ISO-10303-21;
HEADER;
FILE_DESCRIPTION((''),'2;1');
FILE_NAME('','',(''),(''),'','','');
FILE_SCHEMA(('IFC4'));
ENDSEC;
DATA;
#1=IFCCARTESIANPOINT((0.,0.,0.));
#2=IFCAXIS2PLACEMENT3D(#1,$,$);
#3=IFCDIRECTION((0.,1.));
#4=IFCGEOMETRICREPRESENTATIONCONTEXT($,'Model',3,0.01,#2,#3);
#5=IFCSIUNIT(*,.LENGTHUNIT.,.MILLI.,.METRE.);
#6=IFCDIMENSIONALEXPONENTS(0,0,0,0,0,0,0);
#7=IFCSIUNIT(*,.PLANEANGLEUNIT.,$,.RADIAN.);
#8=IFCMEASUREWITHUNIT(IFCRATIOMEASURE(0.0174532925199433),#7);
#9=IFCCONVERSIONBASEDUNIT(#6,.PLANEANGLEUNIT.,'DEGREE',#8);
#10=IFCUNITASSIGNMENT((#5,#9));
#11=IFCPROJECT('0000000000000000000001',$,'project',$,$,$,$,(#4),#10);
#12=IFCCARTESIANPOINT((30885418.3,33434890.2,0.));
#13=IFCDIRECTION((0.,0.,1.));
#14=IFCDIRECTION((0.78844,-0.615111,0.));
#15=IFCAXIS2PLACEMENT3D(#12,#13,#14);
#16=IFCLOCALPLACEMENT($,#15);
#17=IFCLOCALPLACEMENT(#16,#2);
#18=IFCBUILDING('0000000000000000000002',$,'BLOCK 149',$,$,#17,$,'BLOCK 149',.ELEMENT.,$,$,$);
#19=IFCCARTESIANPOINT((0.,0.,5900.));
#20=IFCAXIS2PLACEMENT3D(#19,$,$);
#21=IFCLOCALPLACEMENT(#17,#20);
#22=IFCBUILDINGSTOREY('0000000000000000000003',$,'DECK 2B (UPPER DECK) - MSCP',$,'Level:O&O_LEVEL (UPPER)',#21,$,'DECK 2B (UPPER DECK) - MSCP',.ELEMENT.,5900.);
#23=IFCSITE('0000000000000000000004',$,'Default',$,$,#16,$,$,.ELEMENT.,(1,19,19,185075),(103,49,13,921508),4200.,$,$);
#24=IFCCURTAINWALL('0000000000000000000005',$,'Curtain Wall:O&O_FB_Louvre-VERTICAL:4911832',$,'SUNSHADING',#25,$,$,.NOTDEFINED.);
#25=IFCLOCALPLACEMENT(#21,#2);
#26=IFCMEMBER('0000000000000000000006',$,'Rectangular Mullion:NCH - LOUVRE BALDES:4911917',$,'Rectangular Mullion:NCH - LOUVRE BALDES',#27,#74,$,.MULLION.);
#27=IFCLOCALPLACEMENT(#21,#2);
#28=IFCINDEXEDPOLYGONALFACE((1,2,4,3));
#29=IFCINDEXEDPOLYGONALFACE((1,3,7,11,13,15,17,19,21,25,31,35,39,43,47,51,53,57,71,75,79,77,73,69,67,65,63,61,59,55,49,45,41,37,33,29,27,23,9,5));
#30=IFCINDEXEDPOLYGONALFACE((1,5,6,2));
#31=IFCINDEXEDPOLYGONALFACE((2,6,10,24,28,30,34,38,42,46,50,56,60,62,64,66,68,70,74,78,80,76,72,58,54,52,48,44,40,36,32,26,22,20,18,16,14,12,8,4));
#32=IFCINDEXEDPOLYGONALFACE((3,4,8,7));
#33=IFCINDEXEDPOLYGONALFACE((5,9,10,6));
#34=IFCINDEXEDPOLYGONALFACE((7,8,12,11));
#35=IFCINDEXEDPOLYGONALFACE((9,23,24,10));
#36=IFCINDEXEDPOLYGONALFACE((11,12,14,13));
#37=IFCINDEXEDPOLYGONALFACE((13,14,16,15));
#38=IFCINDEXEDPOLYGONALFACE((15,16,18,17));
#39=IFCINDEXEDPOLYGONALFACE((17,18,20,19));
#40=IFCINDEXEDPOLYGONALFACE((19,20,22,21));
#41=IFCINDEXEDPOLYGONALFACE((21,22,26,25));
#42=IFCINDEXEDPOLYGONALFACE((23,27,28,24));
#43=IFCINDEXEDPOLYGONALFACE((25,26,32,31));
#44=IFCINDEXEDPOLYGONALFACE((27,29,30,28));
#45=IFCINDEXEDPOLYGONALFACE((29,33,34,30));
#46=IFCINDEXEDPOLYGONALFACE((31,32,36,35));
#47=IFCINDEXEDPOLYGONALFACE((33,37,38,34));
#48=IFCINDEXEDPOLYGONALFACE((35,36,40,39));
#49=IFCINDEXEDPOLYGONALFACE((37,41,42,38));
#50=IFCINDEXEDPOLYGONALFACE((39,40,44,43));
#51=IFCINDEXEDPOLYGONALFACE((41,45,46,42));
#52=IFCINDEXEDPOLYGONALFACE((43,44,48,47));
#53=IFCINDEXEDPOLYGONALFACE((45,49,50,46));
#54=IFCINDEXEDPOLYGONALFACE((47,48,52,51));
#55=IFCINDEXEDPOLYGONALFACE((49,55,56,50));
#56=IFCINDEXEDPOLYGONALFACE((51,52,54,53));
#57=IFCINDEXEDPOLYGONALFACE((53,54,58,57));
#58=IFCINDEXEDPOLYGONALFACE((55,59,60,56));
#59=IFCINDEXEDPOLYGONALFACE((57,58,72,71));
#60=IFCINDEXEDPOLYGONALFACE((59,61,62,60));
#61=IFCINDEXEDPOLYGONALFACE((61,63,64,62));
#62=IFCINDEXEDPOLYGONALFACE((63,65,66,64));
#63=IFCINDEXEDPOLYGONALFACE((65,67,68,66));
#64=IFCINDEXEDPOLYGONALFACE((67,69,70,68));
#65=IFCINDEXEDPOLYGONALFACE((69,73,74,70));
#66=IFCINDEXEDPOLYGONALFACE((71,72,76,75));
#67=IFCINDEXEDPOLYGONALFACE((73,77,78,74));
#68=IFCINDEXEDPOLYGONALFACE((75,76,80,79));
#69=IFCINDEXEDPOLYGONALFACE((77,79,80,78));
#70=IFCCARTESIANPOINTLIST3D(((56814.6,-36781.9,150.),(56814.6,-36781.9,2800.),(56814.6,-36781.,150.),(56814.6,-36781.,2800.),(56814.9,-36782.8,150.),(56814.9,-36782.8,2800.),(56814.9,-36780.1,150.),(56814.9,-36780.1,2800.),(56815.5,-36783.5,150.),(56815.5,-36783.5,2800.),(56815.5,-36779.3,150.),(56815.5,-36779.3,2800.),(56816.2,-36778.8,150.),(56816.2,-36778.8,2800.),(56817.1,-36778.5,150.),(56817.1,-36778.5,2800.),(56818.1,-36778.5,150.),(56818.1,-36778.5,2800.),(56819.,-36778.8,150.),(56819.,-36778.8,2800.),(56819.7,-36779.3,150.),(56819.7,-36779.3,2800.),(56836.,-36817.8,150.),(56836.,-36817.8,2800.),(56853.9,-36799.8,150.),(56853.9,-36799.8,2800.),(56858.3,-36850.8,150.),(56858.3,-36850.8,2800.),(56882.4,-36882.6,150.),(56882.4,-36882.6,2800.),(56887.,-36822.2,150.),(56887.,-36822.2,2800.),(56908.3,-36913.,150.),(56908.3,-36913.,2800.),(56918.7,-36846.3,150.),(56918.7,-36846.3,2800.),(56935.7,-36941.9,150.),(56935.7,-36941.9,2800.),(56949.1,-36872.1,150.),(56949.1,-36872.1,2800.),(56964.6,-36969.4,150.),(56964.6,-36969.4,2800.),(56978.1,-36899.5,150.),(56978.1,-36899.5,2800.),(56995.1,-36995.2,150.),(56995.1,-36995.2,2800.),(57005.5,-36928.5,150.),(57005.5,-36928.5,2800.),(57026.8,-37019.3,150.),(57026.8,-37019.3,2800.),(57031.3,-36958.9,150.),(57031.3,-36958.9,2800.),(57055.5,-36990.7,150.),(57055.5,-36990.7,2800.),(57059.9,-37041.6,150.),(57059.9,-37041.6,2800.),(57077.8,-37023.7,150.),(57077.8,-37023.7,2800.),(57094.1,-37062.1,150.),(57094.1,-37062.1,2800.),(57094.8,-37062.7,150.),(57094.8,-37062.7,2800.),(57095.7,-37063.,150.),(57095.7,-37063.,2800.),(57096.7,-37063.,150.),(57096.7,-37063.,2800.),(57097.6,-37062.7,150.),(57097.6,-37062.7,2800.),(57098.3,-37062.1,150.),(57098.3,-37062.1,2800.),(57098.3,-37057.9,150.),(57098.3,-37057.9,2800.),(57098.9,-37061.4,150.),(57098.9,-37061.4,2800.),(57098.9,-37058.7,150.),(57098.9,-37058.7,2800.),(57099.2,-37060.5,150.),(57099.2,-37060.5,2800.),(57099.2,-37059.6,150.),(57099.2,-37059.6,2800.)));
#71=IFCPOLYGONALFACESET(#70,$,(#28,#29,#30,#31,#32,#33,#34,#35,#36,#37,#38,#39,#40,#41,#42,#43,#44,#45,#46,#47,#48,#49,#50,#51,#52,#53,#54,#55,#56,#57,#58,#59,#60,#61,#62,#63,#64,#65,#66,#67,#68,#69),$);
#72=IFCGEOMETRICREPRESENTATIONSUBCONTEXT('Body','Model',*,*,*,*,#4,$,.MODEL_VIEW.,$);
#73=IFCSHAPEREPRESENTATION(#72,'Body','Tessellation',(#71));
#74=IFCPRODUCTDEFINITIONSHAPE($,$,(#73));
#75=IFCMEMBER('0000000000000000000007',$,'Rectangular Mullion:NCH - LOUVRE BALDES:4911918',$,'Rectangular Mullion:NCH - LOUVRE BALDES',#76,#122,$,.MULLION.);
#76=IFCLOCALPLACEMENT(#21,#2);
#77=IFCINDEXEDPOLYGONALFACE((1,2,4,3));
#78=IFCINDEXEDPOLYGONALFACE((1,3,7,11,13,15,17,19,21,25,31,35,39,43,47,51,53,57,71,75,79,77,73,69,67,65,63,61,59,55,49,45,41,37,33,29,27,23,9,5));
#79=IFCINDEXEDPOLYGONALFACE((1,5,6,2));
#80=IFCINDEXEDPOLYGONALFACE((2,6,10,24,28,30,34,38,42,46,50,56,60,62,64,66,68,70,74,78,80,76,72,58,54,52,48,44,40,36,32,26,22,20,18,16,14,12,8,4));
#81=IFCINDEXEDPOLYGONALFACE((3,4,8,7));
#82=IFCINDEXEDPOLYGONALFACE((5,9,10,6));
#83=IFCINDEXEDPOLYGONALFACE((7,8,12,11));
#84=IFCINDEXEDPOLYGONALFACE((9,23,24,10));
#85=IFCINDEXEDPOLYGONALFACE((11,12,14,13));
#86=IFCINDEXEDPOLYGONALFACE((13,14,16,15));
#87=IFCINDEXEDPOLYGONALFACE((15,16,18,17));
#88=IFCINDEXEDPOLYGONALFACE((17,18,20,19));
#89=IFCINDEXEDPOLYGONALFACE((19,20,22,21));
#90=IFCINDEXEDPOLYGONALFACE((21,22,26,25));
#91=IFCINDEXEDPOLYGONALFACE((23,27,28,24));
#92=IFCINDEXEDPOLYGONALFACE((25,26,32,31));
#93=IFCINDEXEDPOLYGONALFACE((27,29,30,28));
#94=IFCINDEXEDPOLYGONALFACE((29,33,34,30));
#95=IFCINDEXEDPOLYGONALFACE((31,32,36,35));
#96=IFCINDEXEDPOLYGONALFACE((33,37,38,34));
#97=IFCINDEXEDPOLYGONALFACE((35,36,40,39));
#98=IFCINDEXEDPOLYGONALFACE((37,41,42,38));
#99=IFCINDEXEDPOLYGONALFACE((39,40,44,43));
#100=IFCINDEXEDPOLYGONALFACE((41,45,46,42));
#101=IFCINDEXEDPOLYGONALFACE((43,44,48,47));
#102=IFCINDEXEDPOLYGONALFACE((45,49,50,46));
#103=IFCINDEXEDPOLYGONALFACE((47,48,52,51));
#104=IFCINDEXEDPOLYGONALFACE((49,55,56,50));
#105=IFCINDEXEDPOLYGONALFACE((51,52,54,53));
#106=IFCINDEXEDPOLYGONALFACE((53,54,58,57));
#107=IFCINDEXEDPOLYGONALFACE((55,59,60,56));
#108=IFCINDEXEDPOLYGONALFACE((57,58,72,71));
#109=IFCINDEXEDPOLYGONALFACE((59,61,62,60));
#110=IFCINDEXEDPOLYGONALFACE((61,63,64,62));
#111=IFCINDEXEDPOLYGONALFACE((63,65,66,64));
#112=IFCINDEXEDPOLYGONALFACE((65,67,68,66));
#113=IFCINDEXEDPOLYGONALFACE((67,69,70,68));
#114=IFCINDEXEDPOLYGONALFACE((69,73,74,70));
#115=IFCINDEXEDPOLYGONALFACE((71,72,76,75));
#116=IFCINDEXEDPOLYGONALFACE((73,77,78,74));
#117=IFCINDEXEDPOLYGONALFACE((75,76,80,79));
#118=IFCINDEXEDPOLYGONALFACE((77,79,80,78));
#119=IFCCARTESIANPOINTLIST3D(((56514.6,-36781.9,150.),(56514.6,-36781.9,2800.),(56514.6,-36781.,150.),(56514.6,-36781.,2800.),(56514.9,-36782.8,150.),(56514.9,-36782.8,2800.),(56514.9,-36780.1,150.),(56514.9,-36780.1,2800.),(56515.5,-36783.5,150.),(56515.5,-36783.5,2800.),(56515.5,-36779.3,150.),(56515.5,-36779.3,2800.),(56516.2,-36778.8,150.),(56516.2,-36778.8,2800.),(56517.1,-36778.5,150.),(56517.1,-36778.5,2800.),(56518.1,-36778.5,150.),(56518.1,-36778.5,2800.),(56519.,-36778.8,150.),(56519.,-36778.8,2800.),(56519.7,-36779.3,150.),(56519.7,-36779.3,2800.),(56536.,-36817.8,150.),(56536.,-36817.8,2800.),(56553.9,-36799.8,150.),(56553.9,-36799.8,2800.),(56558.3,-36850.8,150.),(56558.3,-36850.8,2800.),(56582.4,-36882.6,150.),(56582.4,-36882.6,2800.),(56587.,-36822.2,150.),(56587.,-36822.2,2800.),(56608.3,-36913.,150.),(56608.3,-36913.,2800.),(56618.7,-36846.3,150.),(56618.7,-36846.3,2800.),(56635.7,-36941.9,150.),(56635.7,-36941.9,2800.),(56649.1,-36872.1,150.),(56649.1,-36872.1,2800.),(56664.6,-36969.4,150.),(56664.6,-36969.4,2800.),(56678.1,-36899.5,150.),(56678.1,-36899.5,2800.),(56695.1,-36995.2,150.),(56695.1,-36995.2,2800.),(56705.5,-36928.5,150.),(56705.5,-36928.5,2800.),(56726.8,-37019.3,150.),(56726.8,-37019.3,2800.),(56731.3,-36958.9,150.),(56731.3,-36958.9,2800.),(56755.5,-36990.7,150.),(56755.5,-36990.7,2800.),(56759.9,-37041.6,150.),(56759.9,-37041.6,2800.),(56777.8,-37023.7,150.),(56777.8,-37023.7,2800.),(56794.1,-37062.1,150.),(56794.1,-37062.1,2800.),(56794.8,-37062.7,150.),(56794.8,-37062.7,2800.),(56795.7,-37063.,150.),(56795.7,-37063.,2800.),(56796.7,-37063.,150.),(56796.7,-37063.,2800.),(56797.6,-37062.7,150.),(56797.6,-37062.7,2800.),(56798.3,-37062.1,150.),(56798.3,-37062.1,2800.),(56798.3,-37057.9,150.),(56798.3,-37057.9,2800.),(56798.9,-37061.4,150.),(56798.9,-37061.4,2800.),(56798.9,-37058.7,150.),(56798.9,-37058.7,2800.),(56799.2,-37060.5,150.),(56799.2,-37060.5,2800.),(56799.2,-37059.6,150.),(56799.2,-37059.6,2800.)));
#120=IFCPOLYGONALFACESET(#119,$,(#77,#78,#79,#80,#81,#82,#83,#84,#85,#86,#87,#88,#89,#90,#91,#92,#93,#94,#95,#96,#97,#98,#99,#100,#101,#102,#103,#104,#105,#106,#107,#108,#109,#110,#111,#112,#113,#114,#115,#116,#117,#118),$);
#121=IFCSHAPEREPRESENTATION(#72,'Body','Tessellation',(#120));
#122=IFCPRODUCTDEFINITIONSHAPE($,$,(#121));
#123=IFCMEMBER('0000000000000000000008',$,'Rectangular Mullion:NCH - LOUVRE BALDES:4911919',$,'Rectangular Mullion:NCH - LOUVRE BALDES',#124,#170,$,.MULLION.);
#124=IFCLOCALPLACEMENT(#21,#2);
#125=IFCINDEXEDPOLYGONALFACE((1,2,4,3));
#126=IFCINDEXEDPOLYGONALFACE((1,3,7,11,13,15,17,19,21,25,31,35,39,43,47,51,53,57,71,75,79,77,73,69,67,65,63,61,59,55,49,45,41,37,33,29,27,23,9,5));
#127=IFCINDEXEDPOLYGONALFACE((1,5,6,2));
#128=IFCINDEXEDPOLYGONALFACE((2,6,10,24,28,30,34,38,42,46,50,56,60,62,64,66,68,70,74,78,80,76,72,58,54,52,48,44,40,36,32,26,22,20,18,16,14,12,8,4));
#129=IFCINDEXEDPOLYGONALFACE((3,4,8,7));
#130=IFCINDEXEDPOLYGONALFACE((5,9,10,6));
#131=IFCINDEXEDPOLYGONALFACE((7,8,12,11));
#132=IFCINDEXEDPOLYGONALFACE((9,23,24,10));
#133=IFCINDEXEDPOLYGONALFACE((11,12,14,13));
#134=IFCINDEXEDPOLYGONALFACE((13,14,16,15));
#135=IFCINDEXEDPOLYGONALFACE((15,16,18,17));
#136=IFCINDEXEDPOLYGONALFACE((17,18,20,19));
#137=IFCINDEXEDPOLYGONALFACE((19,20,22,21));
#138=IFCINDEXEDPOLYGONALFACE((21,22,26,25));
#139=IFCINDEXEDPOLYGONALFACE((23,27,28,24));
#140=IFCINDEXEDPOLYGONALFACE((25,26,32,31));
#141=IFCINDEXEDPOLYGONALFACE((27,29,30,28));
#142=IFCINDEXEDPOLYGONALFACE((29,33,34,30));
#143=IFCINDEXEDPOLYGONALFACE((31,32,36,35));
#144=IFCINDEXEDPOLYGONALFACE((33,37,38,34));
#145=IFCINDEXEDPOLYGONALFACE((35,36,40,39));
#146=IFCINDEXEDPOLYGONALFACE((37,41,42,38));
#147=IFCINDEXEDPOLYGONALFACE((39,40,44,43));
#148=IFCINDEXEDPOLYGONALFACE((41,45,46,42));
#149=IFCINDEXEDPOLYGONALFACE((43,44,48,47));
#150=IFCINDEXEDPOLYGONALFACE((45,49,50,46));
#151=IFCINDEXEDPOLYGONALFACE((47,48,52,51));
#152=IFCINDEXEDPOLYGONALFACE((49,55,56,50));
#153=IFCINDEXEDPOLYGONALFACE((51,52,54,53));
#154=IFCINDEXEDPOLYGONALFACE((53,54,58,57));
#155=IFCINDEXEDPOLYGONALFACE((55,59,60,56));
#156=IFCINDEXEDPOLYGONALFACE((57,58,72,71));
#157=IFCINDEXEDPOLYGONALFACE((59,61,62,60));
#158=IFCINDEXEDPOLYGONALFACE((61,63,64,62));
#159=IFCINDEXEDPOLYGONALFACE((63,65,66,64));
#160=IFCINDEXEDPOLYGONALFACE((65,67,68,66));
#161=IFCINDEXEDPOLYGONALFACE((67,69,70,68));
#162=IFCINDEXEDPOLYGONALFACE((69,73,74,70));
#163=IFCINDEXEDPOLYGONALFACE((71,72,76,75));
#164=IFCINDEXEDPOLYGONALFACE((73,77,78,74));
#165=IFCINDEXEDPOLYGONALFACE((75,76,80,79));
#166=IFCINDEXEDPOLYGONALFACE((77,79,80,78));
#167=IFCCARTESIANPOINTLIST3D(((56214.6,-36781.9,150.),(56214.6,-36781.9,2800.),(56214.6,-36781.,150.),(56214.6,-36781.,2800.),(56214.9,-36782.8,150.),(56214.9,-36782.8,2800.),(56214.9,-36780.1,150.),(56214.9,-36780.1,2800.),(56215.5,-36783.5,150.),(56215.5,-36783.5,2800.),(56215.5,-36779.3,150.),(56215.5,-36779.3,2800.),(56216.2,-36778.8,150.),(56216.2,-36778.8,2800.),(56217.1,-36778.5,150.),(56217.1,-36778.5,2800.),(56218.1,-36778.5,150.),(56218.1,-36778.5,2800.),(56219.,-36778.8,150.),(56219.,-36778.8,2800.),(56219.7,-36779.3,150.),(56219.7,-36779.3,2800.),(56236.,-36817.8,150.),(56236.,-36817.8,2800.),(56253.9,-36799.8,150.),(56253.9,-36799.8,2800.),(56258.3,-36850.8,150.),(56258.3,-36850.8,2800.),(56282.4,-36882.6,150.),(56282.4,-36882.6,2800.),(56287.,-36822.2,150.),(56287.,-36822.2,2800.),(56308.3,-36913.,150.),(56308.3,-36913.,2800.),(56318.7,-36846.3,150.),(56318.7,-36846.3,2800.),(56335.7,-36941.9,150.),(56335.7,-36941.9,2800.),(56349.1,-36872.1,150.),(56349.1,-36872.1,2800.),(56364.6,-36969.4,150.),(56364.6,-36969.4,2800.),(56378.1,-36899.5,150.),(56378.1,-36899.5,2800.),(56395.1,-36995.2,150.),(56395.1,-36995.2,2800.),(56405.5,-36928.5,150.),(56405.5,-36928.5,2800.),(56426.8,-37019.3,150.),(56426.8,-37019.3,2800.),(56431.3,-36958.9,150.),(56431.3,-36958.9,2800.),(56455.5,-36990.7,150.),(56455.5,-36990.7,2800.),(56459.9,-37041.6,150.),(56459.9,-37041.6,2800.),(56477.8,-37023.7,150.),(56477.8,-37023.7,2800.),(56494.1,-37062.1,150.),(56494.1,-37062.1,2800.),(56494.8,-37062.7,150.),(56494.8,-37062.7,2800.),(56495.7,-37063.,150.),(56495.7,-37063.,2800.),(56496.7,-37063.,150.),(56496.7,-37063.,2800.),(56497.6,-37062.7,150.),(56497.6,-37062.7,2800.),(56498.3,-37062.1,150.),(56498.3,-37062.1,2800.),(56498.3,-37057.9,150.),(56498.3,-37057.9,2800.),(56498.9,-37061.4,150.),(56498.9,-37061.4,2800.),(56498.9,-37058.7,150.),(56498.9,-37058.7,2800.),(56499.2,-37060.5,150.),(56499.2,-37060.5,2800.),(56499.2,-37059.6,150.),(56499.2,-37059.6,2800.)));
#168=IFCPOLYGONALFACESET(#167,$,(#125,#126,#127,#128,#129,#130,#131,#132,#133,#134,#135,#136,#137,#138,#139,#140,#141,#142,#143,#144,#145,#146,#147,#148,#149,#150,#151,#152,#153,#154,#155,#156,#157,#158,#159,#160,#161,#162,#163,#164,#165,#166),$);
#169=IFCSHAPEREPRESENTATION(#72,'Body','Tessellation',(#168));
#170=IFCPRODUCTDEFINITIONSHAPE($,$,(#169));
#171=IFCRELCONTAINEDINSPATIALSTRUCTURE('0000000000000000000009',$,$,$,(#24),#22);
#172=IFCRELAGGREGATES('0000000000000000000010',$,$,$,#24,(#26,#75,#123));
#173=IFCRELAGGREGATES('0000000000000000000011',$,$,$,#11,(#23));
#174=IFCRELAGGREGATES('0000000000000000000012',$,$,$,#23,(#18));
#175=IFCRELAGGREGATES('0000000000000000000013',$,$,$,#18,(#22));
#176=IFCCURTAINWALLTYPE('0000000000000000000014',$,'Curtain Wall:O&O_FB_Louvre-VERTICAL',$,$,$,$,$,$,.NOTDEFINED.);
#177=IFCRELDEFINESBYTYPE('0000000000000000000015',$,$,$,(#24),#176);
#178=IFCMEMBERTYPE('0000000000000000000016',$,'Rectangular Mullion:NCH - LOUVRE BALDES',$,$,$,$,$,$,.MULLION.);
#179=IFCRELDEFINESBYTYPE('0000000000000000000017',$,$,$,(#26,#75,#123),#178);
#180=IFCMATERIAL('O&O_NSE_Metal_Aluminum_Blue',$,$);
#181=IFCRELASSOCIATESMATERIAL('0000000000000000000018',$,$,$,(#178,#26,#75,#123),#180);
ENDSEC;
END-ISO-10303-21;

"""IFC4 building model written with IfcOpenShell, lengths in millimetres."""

from ifc_helpers import new_model, entity, si_unit, converted_unit, direction, frame, origin, place, context, subcontext, project, spatial, indexed_curve, outline, extrude, source, transform, mapped, material, type_object, type_shapes, element, aggregate, save


model = new_model("IFC4")

# Units and contexts
model_context = context("Model", 3, precision=0.01, world=origin(), true_north=direction((0.0, 1.0)))
body_context = subcontext(model_context, "Body", "Model", "MODEL_VIEW")
ifc_project = project(units=[si_unit("LENGTHUNIT", "METRE", prefix="MILLI"), converted_unit("PLANEANGLEUNIT", "DEGREE", entity("IfcRatioMeasure", 0.0174532925199433), si_unit("PLANEANGLEUNIT", "RADIAN"), dimensions=[0, 0, 0, 0, 0, 0, 0])], contexts=[model_context])

# Site, building, storey
site_placement = place(None, frame((30885418.3, 33434890.2, 0.0), z_axis=(0.0, 0.0, 1.0), x_axis=(0.78844, -0.615111, 0.0)))
site = spatial("IfcSite", under=ifc_project, at=site_placement, Name="Default", CompositionType="ELEMENT", RefLatitude=(1, 19, 19, 185075), RefLongitude=(103, 49, 13, 921508), RefElevation=4200.0)
building_placement = place(site_placement, origin())
building = spatial("IfcBuilding", under=site, at=building_placement, Name="BLOCK 149", LongName="BLOCK 149", CompositionType="ELEMENT")
storey_placement = place(building_placement, frame((0.0, 0.0, 5900.0)))
storey = spatial("IfcBuildingStorey", under=building, at=storey_placement, Name="DECK 2B (UPPER DECK) - MSCP", ObjectType="Level:O&O_LEVEL (UPPER)", LongName="DECK 2B (UPPER DECK) - MSCP", CompositionType="ELEMENT", Elevation=5900.0)

# Curtain wall, members
curtain_wall_type = type_object("IfcCurtainWallType", Name="Curtain Wall:O&O_FB_Louvre-VERTICAL", PredefinedType="NOTDEFINED")
curtain_wall_placement = place(storey_placement, frame((0.0, 0.0, -5900.0)))
curtain_wall = element("IfcCurtainWall", 1, at=curtain_wall_placement, inside=storey, type_object=curtain_wall_type, Name="Curtain Wall:O&O_FB_Louvre-VERTICAL:4911832", ObjectType="SUNSHADING", PredefinedType="NOTDEFINED")
placement = place(building_placement, origin())
ifc_material_1 = material(Name="O&O_NSE_Metal_Aluminum_Blue")
member_type_1 = type_object("IfcMemberType", Name="Rectangular Mullion:NCH - LOUVRE BALDES", PredefinedType="MULLION", material=ifc_material_1)
shared_shape_1 = source(origin(), body_context, "Body", "SweptSolid", [
    extrude(outline(indexed_curve([(55.9, -188.9), (54.8, -149.1), (51.6, -109.3), (46.1, -69.8), (38.6, -30.6), (28.9, 8.1), (17.1, 46.2), (3.3, 83.6), (-12.6, 120.2), (-30.4, 155.9), (-50.1, 190.5), (-50.5, 191.4), (-51.1, 192.1), (-52.0, 192.5), (-52.9, 192.7), (-53.8, 192.6), (-54.7, 192.2), (-55.4, 191.6), (-55.8, 190.8), (-56.0, 189.9), (-55.9, 188.9), (-54.8, 149.1), (-51.6, 109.3), (-46.1, 69.8), (-38.6, 30.6), (-28.9, -8.1), (-17.1, -46.2), (-3.3, -83.6), (12.6, -120.2), (30.4, -155.9), (50.1, -190.5), (50.5, -191.4), (51.1, -192.1), (52.0, -192.5), (52.9, -192.7), (53.8, -192.6), (54.7, -192.2), (55.4, -191.6), (55.8, -190.8), (56.0, -189.9), (55.9, -188.9)], self_intersect=False)), frame((0.0, 0.0, -2650.0), z_axis=(0.0, 0.0, 1.0), x_axis=(0.490779, -0.871284, 0.0)), (0.0, 0.0, 1.0), 2650.0),
])
type_shapes(member_type_1, [shared_shape_1])
member_1_placement = place(placement, frame((56956.9, -36920.7, 6050.0), z_axis=(0.0, 0.0, -1.0), x_axis=(-1.0, 0.0, 0.0)))
member_1 = element("IfcMember", 2, at=member_1_placement, type_object=member_type_1, material=ifc_material_1, Name="Rectangular Mullion:NCH - LOUVRE BALDES:4911917", ObjectType="Rectangular Mullion:NCH - LOUVRE BALDES", PredefinedType="MULLION", context=body_context, shape_type="MappedRepresentation", body=[
    mapped(shared_shape_1, transform((0.0, 0.0, 0.0), scale=1.0)),
])
member_2_placement = place(placement, frame((56656.9, -36920.7, 6050.0), z_axis=(0.0, 0.0, -1.0), x_axis=(-1.0, 0.0, 0.0)))
member_2 = element("IfcMember", 3, at=member_2_placement, type_object=member_type_1, material=ifc_material_1, Name="Rectangular Mullion:NCH - LOUVRE BALDES:4911918", ObjectType="Rectangular Mullion:NCH - LOUVRE BALDES", PredefinedType="MULLION", context=body_context, shape_type="MappedRepresentation", body=[
    mapped(shared_shape_1, transform((0.0, 0.0, 0.0), scale=1.0)),
])
member_3_placement = place(placement, frame((56356.9, -36920.7, 6050.0), z_axis=(0.0, 0.0, -1.0), x_axis=(-1.0, 0.0, 0.0)))
member_3 = element("IfcMember", 4, at=member_3_placement, type_object=member_type_1, material=ifc_material_1, Name="Rectangular Mullion:NCH - LOUVRE BALDES:4911919", ObjectType="Rectangular Mullion:NCH - LOUVRE BALDES", PredefinedType="MULLION", context=body_context, shape_type="MappedRepresentation", body=[
    mapped(shared_shape_1, transform((0.0, 0.0, 0.0), scale=1.0)),
])
aggregate(curtain_wall, [member_1, member_2, member_3])

save(model, "model.ifc")
